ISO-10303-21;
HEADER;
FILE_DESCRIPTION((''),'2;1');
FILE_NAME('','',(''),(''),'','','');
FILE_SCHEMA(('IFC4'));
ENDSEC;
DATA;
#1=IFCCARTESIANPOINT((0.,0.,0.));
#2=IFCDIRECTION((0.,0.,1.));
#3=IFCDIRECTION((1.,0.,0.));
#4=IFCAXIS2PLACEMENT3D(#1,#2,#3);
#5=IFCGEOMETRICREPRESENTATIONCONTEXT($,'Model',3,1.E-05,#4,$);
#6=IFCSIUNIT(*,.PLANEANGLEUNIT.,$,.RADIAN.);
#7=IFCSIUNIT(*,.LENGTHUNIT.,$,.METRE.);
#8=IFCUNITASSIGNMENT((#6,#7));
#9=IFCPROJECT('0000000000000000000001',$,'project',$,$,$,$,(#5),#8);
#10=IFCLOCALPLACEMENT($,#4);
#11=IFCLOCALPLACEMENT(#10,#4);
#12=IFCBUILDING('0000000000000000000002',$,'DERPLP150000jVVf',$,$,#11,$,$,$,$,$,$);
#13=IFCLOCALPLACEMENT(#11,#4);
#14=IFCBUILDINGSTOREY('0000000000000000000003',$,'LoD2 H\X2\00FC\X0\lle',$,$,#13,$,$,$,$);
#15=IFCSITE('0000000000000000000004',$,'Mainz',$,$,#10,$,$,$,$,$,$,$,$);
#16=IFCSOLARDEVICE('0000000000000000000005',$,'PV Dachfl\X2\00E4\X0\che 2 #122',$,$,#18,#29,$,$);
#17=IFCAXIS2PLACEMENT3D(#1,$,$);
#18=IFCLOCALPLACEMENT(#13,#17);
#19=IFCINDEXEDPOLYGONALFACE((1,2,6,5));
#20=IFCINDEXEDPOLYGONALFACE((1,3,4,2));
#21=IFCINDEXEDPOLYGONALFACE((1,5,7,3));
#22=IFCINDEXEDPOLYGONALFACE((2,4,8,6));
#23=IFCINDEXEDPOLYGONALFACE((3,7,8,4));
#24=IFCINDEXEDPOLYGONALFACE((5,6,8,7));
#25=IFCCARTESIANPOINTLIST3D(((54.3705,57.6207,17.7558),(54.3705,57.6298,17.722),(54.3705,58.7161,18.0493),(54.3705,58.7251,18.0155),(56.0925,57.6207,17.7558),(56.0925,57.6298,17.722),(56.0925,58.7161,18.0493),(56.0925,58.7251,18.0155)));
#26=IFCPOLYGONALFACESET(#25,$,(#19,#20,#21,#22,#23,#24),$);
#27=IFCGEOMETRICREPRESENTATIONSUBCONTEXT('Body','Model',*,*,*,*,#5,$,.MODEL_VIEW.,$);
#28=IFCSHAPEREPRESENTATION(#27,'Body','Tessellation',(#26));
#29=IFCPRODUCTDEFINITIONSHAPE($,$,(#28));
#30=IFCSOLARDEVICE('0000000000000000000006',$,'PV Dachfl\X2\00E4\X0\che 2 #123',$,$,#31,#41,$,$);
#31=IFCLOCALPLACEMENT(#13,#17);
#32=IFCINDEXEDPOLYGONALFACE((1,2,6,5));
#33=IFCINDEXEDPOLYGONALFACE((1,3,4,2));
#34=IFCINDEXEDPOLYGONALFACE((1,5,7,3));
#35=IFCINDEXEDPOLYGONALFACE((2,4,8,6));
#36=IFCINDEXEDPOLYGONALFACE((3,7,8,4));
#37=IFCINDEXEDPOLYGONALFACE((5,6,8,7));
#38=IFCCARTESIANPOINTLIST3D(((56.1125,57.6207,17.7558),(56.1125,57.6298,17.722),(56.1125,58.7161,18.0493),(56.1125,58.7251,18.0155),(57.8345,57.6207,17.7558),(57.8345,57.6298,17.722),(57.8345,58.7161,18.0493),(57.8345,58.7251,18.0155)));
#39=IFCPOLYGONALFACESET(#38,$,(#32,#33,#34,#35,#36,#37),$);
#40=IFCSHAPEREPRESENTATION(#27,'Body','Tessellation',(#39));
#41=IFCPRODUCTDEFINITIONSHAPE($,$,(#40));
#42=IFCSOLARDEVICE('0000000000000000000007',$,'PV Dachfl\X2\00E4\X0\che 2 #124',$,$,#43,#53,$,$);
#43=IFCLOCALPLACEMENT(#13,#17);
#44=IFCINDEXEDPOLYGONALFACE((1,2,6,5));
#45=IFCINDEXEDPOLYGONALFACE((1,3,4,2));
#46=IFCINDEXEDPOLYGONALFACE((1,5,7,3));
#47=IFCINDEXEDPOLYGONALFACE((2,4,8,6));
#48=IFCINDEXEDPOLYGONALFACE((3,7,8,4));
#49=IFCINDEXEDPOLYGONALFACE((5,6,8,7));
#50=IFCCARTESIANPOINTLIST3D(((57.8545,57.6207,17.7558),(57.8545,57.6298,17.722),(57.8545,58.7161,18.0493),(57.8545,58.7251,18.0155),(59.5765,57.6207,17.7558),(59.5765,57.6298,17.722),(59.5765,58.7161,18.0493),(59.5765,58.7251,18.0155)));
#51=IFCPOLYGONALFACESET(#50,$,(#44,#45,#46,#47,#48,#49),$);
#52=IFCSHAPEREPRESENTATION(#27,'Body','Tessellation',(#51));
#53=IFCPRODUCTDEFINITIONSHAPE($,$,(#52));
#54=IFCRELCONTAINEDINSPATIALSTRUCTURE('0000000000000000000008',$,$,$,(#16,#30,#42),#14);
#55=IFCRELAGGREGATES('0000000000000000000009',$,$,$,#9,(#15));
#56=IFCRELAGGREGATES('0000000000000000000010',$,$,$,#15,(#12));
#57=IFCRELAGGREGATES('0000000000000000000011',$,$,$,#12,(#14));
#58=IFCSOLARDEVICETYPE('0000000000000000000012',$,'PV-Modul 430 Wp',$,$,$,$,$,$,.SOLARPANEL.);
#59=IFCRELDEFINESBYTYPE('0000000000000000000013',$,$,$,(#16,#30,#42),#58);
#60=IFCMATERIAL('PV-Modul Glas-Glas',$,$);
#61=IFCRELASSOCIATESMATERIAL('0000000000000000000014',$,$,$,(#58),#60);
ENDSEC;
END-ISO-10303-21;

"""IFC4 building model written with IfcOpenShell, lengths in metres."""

from ifc_helpers import new_model, si_unit, frame, frame_2d, origin, origin_with_axes, place, context, subcontext, project, spatial, rectangle, extrude, source, transform, mapped, material, type_object, type_shapes, element, save


model = new_model("IFC4")

# Units and contexts
model_context = context("Model", 3, precision=1e-05, world=origin_with_axes())
body_context = subcontext(model_context, "Body", "Model", "MODEL_VIEW")
ifc_project = project(units=[si_unit("PLANEANGLEUNIT", "RADIAN"), si_unit("LENGTHUNIT", "METRE")], contexts=[model_context])

# Site, building, storey
site_placement = place(None, origin_with_axes())
site = spatial("IfcSite", under=ifc_project, at=site_placement, Name="Mainz")
building_placement = place(site_placement, origin_with_axes())
building = spatial("IfcBuilding", under=site, at=building_placement, Name="DERPLP150000jVVf")
storey_placement = place(building_placement, origin_with_axes())
storey = spatial("IfcBuildingStorey", under=building, at=storey_placement, Name="LoD2 Hülle")

# Solar devices
ifc_material = material(Name="PV-Modul Glas-Glas")
solar_device_type = type_object("IfcSolarDeviceType", Name="PV-Modul 430 Wp", PredefinedType="SOLARPANEL", material=ifc_material)
shared_shape = source(origin_with_axes(), body_context, "Body", "SweptSolid", [
    extrude(rectangle(XDim=1.722, YDim=1.134, at=frame_2d((0.861, 0.567))), origin(), (0.0, 0.0, 1.0), 0.035),
])
type_shapes(solar_device_type, [shared_shape])
for number, where, z_axis, x_axis, name in (
    (1, (54.3705, 57.6298, 17.722), (0.0, -0.258819, 0.965926), (1.0, 0.0, 0.0), "PV Dachfläche 2 #122"),
    (2, (56.1125, 57.6298, 17.722), (0.0, -0.258819, 0.965926), (1.0, 0.0, 0.0), "PV Dachfläche 2 #123"),
    (3, (57.8545, 57.6298, 17.722), (0.0, -0.258819, 0.965926), (1.0, 0.0, 0.0), "PV Dachfläche 2 #124"),
):
    element("IfcSolarDevice", number, at=place(storey_placement, frame(where, z_axis=z_axis, x_axis=x_axis)), inside=storey, type_object=solar_device_type, Name=name, context=body_context, shape_type="MappedRepresentation", body=[
        mapped(shared_shape, transform((0.0, 0.0, 0.0), x_axis=(1.0, 0.0, 0.0), y_axis=(0.0, 1.0, 0.0), z_axis=(0.0, 0.0, 1.0), scale=1.0)),
    ])

save(model, "model.ifc")
